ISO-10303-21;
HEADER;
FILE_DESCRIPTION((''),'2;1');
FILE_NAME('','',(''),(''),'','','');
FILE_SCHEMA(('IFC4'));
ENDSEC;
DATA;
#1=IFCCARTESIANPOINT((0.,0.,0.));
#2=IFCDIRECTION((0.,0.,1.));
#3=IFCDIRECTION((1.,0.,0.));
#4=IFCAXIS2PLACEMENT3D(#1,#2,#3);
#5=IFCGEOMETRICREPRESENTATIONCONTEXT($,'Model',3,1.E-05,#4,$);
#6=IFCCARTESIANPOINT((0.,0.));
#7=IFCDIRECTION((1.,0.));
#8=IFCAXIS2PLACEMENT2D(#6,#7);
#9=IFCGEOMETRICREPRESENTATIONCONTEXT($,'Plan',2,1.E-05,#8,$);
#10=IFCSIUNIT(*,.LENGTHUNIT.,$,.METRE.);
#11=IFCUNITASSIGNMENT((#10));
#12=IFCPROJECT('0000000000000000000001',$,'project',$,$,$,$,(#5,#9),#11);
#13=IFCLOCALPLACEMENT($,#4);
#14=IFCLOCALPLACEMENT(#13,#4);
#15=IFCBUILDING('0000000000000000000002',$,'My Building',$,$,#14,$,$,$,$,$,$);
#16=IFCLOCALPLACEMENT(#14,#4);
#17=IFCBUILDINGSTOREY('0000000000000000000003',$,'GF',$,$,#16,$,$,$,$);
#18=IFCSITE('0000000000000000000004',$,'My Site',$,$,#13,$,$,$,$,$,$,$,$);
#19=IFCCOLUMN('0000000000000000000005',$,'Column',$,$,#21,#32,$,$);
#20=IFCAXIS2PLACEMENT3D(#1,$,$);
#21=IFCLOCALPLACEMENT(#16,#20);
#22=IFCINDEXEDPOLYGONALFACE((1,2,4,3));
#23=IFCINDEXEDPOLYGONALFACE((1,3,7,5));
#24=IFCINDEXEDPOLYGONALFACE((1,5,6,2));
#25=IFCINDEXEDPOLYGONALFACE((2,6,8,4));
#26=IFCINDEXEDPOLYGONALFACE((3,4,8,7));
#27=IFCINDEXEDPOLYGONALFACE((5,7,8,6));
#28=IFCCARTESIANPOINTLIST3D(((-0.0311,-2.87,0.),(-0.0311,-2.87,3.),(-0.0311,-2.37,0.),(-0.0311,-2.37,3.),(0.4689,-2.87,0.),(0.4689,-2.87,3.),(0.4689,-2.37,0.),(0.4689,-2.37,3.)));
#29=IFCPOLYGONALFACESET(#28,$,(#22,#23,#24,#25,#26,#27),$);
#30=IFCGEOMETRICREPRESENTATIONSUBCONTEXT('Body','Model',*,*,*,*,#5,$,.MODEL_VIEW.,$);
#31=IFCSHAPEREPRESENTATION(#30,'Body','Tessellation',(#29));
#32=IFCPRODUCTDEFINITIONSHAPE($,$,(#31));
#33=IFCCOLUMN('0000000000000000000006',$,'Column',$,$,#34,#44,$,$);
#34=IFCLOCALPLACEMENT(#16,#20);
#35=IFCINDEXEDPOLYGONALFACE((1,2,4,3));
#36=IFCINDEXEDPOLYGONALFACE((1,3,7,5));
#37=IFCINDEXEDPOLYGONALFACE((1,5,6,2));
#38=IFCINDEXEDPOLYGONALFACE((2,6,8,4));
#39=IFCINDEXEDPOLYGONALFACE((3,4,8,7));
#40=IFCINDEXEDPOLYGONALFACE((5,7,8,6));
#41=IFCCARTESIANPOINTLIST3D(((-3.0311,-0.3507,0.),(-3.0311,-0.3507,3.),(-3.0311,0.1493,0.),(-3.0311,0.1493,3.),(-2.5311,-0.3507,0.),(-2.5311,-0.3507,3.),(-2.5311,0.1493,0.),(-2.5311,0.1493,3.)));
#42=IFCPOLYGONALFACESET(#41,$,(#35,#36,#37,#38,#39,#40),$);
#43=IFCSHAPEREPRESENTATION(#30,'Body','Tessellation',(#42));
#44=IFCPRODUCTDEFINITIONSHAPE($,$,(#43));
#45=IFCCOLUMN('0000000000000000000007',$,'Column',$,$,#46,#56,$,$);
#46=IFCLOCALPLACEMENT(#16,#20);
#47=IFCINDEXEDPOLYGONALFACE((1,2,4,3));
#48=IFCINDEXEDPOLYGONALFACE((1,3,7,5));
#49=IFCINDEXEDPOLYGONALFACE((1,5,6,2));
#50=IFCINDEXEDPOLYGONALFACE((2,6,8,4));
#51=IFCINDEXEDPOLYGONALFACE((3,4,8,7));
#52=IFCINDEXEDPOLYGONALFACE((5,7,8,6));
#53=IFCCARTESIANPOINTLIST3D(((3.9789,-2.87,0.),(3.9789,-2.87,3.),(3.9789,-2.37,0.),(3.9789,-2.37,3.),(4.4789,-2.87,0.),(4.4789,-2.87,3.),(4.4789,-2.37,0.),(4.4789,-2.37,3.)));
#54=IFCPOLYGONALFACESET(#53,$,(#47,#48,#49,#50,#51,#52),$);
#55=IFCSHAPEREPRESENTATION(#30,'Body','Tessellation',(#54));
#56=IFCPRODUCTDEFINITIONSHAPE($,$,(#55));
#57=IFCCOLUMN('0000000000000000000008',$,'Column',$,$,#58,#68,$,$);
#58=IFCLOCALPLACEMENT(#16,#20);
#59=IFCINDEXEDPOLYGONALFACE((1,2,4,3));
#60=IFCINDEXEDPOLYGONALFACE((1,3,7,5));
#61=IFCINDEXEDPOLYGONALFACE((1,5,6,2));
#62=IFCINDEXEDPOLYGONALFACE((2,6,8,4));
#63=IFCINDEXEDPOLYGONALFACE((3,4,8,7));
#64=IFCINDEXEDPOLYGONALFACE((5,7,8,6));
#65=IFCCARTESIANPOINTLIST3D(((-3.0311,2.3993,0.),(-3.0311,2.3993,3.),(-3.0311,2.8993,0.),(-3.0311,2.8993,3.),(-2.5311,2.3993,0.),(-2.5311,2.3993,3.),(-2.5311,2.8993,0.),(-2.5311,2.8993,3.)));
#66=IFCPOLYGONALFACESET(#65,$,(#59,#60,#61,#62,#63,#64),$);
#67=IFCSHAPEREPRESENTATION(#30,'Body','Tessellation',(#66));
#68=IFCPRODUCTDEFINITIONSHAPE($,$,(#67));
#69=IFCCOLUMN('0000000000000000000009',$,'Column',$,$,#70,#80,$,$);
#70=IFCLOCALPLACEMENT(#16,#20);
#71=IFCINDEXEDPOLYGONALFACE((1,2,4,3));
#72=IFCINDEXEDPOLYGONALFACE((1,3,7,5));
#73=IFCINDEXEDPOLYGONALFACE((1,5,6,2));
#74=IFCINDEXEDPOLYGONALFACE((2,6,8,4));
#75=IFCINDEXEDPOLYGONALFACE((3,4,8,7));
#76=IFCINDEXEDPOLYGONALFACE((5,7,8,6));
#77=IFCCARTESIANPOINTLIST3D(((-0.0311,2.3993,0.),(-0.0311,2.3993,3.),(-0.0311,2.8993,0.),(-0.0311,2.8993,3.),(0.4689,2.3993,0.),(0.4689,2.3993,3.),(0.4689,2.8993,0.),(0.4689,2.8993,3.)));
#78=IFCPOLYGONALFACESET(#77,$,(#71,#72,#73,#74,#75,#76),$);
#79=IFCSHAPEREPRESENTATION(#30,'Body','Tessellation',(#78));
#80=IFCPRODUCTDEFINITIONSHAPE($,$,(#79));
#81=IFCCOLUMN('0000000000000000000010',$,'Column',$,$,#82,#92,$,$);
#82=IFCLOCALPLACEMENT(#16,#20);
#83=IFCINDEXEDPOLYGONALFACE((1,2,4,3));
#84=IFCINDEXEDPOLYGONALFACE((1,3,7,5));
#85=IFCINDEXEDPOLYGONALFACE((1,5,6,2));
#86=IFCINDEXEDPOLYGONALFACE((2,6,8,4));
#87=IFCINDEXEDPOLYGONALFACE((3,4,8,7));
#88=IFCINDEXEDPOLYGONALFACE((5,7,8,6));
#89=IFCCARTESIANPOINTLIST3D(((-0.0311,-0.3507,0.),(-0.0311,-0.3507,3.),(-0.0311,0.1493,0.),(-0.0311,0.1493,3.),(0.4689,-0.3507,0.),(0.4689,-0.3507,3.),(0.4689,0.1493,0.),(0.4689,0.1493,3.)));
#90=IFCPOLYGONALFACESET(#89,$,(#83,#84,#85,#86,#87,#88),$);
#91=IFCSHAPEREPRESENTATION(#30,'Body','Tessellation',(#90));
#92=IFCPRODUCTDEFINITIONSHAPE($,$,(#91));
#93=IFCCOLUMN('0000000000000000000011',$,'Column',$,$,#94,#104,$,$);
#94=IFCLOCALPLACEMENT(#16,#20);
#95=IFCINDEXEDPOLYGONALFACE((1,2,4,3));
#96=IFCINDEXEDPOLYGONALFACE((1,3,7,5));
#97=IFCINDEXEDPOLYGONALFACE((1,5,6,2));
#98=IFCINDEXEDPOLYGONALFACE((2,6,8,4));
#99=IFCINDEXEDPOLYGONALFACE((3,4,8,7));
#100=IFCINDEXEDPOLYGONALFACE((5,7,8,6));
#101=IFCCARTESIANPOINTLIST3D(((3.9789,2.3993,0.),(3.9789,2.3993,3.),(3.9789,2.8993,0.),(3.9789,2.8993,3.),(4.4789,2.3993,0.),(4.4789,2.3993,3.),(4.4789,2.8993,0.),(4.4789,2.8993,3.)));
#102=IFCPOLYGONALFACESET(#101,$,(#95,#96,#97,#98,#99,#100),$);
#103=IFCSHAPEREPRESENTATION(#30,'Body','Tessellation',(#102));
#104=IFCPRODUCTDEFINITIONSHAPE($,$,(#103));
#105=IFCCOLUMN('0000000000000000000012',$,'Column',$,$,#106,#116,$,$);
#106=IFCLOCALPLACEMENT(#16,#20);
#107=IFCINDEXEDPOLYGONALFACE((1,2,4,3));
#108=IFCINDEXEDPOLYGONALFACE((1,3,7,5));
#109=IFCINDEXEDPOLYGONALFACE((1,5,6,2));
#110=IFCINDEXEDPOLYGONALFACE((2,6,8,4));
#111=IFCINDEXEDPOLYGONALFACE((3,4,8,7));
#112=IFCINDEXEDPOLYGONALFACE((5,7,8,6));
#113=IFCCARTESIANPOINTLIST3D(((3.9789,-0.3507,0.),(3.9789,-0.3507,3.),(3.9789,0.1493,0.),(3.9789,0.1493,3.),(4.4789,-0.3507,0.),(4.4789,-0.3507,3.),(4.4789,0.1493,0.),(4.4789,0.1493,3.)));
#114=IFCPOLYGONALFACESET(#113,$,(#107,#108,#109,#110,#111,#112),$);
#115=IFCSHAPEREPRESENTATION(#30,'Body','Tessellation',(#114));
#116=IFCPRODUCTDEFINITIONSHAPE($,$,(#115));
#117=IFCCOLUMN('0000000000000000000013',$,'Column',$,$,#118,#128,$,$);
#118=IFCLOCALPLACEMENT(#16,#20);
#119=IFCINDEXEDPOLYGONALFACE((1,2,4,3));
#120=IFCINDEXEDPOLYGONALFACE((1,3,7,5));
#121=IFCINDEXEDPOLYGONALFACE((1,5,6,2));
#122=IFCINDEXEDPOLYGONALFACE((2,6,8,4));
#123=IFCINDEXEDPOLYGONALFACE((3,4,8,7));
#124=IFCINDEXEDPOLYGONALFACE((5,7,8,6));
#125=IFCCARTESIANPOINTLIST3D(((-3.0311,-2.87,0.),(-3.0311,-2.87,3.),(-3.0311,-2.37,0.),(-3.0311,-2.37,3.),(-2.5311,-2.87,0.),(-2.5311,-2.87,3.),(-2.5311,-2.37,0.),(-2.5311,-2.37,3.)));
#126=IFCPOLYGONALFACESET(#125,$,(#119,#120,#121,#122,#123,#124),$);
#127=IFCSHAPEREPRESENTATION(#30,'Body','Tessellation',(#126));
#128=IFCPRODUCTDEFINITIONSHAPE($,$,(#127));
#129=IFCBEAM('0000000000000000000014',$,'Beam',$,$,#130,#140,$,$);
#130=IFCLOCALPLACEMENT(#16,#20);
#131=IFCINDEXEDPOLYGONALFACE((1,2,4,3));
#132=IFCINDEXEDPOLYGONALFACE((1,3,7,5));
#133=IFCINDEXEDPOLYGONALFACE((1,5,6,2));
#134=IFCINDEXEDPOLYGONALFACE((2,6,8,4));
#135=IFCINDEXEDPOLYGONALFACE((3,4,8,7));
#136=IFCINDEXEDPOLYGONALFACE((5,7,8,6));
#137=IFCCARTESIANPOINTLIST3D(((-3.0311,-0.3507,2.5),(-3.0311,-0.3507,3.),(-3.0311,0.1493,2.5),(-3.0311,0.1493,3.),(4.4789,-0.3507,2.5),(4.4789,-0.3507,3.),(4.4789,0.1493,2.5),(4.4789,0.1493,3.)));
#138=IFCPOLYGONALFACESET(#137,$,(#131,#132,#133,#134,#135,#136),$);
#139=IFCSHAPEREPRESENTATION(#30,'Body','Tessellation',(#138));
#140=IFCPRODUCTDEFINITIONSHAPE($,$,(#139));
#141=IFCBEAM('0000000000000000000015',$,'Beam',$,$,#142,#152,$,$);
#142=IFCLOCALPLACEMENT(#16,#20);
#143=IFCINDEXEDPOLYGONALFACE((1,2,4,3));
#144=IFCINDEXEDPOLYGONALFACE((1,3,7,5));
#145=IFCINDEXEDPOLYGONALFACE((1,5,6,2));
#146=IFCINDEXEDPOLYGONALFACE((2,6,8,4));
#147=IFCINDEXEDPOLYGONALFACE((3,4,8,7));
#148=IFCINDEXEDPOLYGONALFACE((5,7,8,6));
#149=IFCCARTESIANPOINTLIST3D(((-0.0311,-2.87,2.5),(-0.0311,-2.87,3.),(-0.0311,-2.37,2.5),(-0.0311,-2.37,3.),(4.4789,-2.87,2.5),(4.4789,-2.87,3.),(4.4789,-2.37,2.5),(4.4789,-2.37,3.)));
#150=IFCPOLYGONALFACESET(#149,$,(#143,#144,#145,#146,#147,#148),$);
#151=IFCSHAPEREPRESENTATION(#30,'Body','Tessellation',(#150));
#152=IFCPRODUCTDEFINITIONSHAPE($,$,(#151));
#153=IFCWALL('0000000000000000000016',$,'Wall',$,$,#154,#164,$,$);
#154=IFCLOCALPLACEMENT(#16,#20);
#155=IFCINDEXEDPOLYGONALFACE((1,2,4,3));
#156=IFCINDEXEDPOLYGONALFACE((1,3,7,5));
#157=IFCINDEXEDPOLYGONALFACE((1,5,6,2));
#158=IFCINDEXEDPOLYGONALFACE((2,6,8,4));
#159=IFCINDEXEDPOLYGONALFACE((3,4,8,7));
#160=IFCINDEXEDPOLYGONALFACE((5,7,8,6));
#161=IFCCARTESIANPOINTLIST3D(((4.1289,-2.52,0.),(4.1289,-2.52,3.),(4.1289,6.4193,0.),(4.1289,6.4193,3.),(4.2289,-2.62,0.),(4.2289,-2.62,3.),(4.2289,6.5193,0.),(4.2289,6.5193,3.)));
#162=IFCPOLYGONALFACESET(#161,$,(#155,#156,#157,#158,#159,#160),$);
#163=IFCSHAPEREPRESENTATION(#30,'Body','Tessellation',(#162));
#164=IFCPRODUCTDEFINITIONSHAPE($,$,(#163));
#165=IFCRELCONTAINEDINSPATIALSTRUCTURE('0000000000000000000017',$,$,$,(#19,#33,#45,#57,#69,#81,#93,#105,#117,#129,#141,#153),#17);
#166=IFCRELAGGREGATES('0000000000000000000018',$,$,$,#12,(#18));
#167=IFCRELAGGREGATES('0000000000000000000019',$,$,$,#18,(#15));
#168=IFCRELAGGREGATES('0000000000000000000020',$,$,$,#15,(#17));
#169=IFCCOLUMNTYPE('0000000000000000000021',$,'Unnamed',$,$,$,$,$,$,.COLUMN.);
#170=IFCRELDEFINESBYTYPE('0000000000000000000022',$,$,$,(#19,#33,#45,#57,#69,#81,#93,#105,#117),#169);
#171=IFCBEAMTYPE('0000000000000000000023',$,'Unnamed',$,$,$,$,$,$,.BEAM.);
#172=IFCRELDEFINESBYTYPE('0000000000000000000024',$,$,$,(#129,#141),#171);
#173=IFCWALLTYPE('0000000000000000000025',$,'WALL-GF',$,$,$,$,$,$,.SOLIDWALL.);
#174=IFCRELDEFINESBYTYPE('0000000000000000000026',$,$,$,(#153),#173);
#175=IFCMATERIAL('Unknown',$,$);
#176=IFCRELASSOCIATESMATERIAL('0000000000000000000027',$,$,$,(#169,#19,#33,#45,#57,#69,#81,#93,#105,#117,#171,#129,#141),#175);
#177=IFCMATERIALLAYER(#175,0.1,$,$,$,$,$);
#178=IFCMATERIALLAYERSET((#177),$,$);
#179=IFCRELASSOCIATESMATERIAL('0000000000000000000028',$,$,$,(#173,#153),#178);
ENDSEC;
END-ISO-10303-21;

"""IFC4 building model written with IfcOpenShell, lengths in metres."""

from ifc_helpers import new_model, si_unit, frame, origin_with_axes, origin_2d_with_axis, place, context, subcontext, project, spatial, line, indexed_curve, rectangle, outline, extrude, material, layer, layer_set, layer_usage, material_profile, profile_set, profile_usage, type_object, element, save


model = new_model("IFC4")

# Units and contexts
model_context = context("Model", 3, precision=1e-05, world=origin_with_axes())
plan_context = context("Plan", 2, precision=1e-05, world=origin_2d_with_axis())
body_context_1 = subcontext(model_context, "Body", "Model", "MODEL_VIEW")
ifc_project = project(units=[si_unit("LENGTHUNIT", "METRE")], contexts=[model_context, plan_context])

# Site, building, storey
site_placement = place(None, origin_with_axes())
site = spatial("IfcSite", under=ifc_project, at=site_placement, Name="My Site")
building_placement = place(site_placement, origin_with_axes())
building = spatial("IfcBuilding", under=site, at=building_placement, Name="My Building")
storey_placement = place(building_placement, origin_with_axes())
storey = spatial("IfcBuildingStorey", under=building, at=storey_placement, Name="GF")

# Columns
ifc_material = material(Name="Unknown")
ifc_material_profile_1 = material_profile(ifc_material, rectangle(XDim=0.5, YDim=0.5))
ifc_profile_set_1 = profile_set([ifc_material_profile_1])
ifc_profile_usage_1 = profile_usage(ifc_profile_set_1, cardinal=5)
column_type = type_object("IfcColumnType", Name="Unnamed", PredefinedType="COLUMN", material=ifc_profile_set_1)
column_1_placement = place(storey_placement, frame((0.2189, -2.62, 0.0), z_axis=(0.0, 0.0, 1.0), x_axis=(1.0, 0.0, 0.0)))
element("IfcColumn", 1, at=column_1_placement, inside=storey, type_object=column_type, material=ifc_profile_usage_1, Name="Column", context=body_context_1, shape_type="SweptSolid", body=[
    extrude(rectangle(XDim=0.5, YDim=0.5), origin_with_axes(), (0.0, 0.0, 1.0), 3.0),
])
ifc_profile_usage_2 = profile_usage(ifc_profile_set_1, cardinal=5)
column_2_placement = place(storey_placement, frame((-2.7811, -0.1007, 0.0), z_axis=(0.0, 0.0, 1.0), x_axis=(1.0, 0.0, 0.0)))
element("IfcColumn", 2, at=column_2_placement, inside=storey, type_object=column_type, material=ifc_profile_usage_2, Name="Column", context=body_context_1, shape_type="SweptSolid", body=[
    extrude(rectangle(XDim=0.5, YDim=0.5), origin_with_axes(), (0.0, 0.0, 1.0), 3.0),
])
ifc_profile_usage_3 = profile_usage(ifc_profile_set_1, cardinal=5)
column_3_placement = place(storey_placement, frame((4.2289, -2.62, 0.0), z_axis=(0.0, 0.0, 1.0), x_axis=(1.0, 0.0, 0.0)))
element("IfcColumn", 3, at=column_3_placement, inside=storey, type_object=column_type, material=ifc_profile_usage_3, Name="Column", context=body_context_1, shape_type="SweptSolid", body=[
    extrude(rectangle(XDim=0.5, YDim=0.5), origin_with_axes(), (0.0, 0.0, 1.0), 3.0),
])
ifc_profile_usage_4 = profile_usage(ifc_profile_set_1, cardinal=5)
column_4_placement = place(storey_placement, frame((-2.7811, 2.6493, 0.0), z_axis=(0.0, 0.0, 1.0), x_axis=(1.0, 0.0, 0.0)))
element("IfcColumn", 4, at=column_4_placement, inside=storey, type_object=column_type, material=ifc_profile_usage_4, Name="Column", context=body_context_1, shape_type="SweptSolid", body=[
    extrude(rectangle(XDim=0.5, YDim=0.5), origin_with_axes(), (0.0, 0.0, 1.0), 3.0),
])
ifc_profile_usage_5 = profile_usage(ifc_profile_set_1, cardinal=5)
column_5_placement = place(storey_placement, frame((0.2189, 2.6493, 0.0), z_axis=(0.0, 0.0, 1.0), x_axis=(1.0, 0.0, 0.0)))
element("IfcColumn", 5, at=column_5_placement, inside=storey, type_object=column_type, material=ifc_profile_usage_5, Name="Column", context=body_context_1, shape_type="SweptSolid", body=[
    extrude(rectangle(XDim=0.5, YDim=0.5), origin_with_axes(), (0.0, 0.0, 1.0), 3.0),
])
ifc_profile_usage_6 = profile_usage(ifc_profile_set_1, cardinal=5)
column_6_placement = place(storey_placement, frame((0.2189, -0.1007, 0.0), z_axis=(0.0, 0.0, 1.0), x_axis=(1.0, 0.0, 0.0)))
element("IfcColumn", 6, at=column_6_placement, inside=storey, type_object=column_type, material=ifc_profile_usage_6, Name="Column", context=body_context_1, shape_type="SweptSolid", body=[
    extrude(rectangle(XDim=0.5, YDim=0.5), origin_with_axes(), (0.0, 0.0, 1.0), 3.0),
])
ifc_profile_usage_7 = profile_usage(ifc_profile_set_1, cardinal=5)
column_7_placement = place(storey_placement, frame((4.2289, 2.6493, 0.0), z_axis=(0.0, 0.0, 1.0), x_axis=(1.0, 0.0, 0.0)))
element("IfcColumn", 7, at=column_7_placement, inside=storey, type_object=column_type, material=ifc_profile_usage_7, Name="Column", context=body_context_1, shape_type="SweptSolid", body=[
    extrude(rectangle(XDim=0.5, YDim=0.5), origin_with_axes(), (0.0, 0.0, 1.0), 3.0),
])
ifc_profile_usage_8 = profile_usage(ifc_profile_set_1, cardinal=5)
column_8_placement = place(storey_placement, frame((4.2289, -0.1007, 0.0), z_axis=(0.0, 0.0, 1.0), x_axis=(1.0, 0.0, 0.0)))
element("IfcColumn", 8, at=column_8_placement, inside=storey, type_object=column_type, material=ifc_profile_usage_8, Name="Column", context=body_context_1, shape_type="SweptSolid", body=[
    extrude(rectangle(XDim=0.5, YDim=0.5), origin_with_axes(), (0.0, 0.0, 1.0), 3.0),
])
ifc_profile_usage_9 = profile_usage(ifc_profile_set_1, cardinal=5)
column_9_placement = place(storey_placement, frame((-2.7811, -2.62, 0.0), z_axis=(0.0, 0.0, 1.0), x_axis=(1.0, 0.0, 0.0)))
element("IfcColumn", 9, at=column_9_placement, inside=storey, type_object=column_type, material=ifc_profile_usage_9, Name="Column", context=body_context_1, shape_type="SweptSolid", body=[
    extrude(rectangle(XDim=0.5, YDim=0.5), origin_with_axes(), (0.0, 0.0, 1.0), 3.0),
])

# Beams
ifc_material_profile_2 = material_profile(ifc_material, rectangle(XDim=0.5, YDim=0.5))
ifc_profile_set_2 = profile_set([ifc_material_profile_2])
ifc_profile_usage_10 = profile_usage(ifc_profile_set_2, cardinal=7)
beam_type = type_object("IfcBeamType", Name="Unnamed", PredefinedType="BEAM", material=ifc_profile_set_2)
beam_1_placement = place(storey_placement, frame((-3.0311, 0.1493, 3.0), z_axis=(1.0, 0.0, 0.0), x_axis=(0.0, 1.0, 0.0)))
element("IfcBeam", 10, at=beam_1_placement, inside=storey, type_object=beam_type, material=ifc_profile_usage_10, Name="Beam", context=body_context_1, shape_type="SweptSolid", body=[
    extrude(rectangle(XDim=0.5, YDim=0.5), frame((-0.25, -0.25, 0.0), z_axis=(0.0, 0.0, 1.0), x_axis=(1.0, 0.0, 0.0)), (0.0, 0.0, 1.0), 7.51),
])
ifc_profile_usage_11 = profile_usage(ifc_profile_set_2, cardinal=7)
beam_2_placement = place(storey_placement, frame((-0.0311, -2.37, 3.0), z_axis=(1.0, 0.0, 0.0), x_axis=(0.0, 1.0, 0.0)))
element("IfcBeam", 11, at=beam_2_placement, inside=storey, type_object=beam_type, material=ifc_profile_usage_11, Name="Beam", context=body_context_1, shape_type="SweptSolid", body=[
    extrude(rectangle(XDim=0.5, YDim=0.5), frame((-0.25, -0.25, 0.0), z_axis=(0.0, 0.0, 1.0), x_axis=(1.0, 0.0, 0.0)), (0.0, 0.0, 1.0), 4.51),
])

# Shared definitions
ifc_layer_1 = layer(ifc_material, 0.1)
ifc_layer_set_1 = layer_set([ifc_layer_1])
wall_type = type_object("IfcWallType", Name="WALL-GF", PredefinedType="SOLIDWALL", material=ifc_layer_set_1)

# Wall
ifc_layer_usage_1 = layer_usage(ifc_layer_set_1, "AXIS2", "POSITIVE", 0.0)
wall_1_placement = place(storey_placement, frame((4.2289, -2.62, 0.0), z_axis=(0.0, 0.0, 1.0), x_axis=(0.0, 1.0, 0.0)))
element("IfcWall", 12, at=wall_1_placement, inside=storey, type_object=wall_type, material=ifc_layer_usage_1, Name="Wall", context=body_context_1, shape_type="SweptSolid", body=[
    extrude(outline(indexed_curve([(0.0, 0.0), (0.1, 0.1), (9.0393, 0.1), (9.1393, 0.0)], segments=[line(1, 2, 3, 4, 1)])), origin_with_axes(), (0.0, 0.0, 1.0), 3.0),
])

save(model, "model.ifc")
